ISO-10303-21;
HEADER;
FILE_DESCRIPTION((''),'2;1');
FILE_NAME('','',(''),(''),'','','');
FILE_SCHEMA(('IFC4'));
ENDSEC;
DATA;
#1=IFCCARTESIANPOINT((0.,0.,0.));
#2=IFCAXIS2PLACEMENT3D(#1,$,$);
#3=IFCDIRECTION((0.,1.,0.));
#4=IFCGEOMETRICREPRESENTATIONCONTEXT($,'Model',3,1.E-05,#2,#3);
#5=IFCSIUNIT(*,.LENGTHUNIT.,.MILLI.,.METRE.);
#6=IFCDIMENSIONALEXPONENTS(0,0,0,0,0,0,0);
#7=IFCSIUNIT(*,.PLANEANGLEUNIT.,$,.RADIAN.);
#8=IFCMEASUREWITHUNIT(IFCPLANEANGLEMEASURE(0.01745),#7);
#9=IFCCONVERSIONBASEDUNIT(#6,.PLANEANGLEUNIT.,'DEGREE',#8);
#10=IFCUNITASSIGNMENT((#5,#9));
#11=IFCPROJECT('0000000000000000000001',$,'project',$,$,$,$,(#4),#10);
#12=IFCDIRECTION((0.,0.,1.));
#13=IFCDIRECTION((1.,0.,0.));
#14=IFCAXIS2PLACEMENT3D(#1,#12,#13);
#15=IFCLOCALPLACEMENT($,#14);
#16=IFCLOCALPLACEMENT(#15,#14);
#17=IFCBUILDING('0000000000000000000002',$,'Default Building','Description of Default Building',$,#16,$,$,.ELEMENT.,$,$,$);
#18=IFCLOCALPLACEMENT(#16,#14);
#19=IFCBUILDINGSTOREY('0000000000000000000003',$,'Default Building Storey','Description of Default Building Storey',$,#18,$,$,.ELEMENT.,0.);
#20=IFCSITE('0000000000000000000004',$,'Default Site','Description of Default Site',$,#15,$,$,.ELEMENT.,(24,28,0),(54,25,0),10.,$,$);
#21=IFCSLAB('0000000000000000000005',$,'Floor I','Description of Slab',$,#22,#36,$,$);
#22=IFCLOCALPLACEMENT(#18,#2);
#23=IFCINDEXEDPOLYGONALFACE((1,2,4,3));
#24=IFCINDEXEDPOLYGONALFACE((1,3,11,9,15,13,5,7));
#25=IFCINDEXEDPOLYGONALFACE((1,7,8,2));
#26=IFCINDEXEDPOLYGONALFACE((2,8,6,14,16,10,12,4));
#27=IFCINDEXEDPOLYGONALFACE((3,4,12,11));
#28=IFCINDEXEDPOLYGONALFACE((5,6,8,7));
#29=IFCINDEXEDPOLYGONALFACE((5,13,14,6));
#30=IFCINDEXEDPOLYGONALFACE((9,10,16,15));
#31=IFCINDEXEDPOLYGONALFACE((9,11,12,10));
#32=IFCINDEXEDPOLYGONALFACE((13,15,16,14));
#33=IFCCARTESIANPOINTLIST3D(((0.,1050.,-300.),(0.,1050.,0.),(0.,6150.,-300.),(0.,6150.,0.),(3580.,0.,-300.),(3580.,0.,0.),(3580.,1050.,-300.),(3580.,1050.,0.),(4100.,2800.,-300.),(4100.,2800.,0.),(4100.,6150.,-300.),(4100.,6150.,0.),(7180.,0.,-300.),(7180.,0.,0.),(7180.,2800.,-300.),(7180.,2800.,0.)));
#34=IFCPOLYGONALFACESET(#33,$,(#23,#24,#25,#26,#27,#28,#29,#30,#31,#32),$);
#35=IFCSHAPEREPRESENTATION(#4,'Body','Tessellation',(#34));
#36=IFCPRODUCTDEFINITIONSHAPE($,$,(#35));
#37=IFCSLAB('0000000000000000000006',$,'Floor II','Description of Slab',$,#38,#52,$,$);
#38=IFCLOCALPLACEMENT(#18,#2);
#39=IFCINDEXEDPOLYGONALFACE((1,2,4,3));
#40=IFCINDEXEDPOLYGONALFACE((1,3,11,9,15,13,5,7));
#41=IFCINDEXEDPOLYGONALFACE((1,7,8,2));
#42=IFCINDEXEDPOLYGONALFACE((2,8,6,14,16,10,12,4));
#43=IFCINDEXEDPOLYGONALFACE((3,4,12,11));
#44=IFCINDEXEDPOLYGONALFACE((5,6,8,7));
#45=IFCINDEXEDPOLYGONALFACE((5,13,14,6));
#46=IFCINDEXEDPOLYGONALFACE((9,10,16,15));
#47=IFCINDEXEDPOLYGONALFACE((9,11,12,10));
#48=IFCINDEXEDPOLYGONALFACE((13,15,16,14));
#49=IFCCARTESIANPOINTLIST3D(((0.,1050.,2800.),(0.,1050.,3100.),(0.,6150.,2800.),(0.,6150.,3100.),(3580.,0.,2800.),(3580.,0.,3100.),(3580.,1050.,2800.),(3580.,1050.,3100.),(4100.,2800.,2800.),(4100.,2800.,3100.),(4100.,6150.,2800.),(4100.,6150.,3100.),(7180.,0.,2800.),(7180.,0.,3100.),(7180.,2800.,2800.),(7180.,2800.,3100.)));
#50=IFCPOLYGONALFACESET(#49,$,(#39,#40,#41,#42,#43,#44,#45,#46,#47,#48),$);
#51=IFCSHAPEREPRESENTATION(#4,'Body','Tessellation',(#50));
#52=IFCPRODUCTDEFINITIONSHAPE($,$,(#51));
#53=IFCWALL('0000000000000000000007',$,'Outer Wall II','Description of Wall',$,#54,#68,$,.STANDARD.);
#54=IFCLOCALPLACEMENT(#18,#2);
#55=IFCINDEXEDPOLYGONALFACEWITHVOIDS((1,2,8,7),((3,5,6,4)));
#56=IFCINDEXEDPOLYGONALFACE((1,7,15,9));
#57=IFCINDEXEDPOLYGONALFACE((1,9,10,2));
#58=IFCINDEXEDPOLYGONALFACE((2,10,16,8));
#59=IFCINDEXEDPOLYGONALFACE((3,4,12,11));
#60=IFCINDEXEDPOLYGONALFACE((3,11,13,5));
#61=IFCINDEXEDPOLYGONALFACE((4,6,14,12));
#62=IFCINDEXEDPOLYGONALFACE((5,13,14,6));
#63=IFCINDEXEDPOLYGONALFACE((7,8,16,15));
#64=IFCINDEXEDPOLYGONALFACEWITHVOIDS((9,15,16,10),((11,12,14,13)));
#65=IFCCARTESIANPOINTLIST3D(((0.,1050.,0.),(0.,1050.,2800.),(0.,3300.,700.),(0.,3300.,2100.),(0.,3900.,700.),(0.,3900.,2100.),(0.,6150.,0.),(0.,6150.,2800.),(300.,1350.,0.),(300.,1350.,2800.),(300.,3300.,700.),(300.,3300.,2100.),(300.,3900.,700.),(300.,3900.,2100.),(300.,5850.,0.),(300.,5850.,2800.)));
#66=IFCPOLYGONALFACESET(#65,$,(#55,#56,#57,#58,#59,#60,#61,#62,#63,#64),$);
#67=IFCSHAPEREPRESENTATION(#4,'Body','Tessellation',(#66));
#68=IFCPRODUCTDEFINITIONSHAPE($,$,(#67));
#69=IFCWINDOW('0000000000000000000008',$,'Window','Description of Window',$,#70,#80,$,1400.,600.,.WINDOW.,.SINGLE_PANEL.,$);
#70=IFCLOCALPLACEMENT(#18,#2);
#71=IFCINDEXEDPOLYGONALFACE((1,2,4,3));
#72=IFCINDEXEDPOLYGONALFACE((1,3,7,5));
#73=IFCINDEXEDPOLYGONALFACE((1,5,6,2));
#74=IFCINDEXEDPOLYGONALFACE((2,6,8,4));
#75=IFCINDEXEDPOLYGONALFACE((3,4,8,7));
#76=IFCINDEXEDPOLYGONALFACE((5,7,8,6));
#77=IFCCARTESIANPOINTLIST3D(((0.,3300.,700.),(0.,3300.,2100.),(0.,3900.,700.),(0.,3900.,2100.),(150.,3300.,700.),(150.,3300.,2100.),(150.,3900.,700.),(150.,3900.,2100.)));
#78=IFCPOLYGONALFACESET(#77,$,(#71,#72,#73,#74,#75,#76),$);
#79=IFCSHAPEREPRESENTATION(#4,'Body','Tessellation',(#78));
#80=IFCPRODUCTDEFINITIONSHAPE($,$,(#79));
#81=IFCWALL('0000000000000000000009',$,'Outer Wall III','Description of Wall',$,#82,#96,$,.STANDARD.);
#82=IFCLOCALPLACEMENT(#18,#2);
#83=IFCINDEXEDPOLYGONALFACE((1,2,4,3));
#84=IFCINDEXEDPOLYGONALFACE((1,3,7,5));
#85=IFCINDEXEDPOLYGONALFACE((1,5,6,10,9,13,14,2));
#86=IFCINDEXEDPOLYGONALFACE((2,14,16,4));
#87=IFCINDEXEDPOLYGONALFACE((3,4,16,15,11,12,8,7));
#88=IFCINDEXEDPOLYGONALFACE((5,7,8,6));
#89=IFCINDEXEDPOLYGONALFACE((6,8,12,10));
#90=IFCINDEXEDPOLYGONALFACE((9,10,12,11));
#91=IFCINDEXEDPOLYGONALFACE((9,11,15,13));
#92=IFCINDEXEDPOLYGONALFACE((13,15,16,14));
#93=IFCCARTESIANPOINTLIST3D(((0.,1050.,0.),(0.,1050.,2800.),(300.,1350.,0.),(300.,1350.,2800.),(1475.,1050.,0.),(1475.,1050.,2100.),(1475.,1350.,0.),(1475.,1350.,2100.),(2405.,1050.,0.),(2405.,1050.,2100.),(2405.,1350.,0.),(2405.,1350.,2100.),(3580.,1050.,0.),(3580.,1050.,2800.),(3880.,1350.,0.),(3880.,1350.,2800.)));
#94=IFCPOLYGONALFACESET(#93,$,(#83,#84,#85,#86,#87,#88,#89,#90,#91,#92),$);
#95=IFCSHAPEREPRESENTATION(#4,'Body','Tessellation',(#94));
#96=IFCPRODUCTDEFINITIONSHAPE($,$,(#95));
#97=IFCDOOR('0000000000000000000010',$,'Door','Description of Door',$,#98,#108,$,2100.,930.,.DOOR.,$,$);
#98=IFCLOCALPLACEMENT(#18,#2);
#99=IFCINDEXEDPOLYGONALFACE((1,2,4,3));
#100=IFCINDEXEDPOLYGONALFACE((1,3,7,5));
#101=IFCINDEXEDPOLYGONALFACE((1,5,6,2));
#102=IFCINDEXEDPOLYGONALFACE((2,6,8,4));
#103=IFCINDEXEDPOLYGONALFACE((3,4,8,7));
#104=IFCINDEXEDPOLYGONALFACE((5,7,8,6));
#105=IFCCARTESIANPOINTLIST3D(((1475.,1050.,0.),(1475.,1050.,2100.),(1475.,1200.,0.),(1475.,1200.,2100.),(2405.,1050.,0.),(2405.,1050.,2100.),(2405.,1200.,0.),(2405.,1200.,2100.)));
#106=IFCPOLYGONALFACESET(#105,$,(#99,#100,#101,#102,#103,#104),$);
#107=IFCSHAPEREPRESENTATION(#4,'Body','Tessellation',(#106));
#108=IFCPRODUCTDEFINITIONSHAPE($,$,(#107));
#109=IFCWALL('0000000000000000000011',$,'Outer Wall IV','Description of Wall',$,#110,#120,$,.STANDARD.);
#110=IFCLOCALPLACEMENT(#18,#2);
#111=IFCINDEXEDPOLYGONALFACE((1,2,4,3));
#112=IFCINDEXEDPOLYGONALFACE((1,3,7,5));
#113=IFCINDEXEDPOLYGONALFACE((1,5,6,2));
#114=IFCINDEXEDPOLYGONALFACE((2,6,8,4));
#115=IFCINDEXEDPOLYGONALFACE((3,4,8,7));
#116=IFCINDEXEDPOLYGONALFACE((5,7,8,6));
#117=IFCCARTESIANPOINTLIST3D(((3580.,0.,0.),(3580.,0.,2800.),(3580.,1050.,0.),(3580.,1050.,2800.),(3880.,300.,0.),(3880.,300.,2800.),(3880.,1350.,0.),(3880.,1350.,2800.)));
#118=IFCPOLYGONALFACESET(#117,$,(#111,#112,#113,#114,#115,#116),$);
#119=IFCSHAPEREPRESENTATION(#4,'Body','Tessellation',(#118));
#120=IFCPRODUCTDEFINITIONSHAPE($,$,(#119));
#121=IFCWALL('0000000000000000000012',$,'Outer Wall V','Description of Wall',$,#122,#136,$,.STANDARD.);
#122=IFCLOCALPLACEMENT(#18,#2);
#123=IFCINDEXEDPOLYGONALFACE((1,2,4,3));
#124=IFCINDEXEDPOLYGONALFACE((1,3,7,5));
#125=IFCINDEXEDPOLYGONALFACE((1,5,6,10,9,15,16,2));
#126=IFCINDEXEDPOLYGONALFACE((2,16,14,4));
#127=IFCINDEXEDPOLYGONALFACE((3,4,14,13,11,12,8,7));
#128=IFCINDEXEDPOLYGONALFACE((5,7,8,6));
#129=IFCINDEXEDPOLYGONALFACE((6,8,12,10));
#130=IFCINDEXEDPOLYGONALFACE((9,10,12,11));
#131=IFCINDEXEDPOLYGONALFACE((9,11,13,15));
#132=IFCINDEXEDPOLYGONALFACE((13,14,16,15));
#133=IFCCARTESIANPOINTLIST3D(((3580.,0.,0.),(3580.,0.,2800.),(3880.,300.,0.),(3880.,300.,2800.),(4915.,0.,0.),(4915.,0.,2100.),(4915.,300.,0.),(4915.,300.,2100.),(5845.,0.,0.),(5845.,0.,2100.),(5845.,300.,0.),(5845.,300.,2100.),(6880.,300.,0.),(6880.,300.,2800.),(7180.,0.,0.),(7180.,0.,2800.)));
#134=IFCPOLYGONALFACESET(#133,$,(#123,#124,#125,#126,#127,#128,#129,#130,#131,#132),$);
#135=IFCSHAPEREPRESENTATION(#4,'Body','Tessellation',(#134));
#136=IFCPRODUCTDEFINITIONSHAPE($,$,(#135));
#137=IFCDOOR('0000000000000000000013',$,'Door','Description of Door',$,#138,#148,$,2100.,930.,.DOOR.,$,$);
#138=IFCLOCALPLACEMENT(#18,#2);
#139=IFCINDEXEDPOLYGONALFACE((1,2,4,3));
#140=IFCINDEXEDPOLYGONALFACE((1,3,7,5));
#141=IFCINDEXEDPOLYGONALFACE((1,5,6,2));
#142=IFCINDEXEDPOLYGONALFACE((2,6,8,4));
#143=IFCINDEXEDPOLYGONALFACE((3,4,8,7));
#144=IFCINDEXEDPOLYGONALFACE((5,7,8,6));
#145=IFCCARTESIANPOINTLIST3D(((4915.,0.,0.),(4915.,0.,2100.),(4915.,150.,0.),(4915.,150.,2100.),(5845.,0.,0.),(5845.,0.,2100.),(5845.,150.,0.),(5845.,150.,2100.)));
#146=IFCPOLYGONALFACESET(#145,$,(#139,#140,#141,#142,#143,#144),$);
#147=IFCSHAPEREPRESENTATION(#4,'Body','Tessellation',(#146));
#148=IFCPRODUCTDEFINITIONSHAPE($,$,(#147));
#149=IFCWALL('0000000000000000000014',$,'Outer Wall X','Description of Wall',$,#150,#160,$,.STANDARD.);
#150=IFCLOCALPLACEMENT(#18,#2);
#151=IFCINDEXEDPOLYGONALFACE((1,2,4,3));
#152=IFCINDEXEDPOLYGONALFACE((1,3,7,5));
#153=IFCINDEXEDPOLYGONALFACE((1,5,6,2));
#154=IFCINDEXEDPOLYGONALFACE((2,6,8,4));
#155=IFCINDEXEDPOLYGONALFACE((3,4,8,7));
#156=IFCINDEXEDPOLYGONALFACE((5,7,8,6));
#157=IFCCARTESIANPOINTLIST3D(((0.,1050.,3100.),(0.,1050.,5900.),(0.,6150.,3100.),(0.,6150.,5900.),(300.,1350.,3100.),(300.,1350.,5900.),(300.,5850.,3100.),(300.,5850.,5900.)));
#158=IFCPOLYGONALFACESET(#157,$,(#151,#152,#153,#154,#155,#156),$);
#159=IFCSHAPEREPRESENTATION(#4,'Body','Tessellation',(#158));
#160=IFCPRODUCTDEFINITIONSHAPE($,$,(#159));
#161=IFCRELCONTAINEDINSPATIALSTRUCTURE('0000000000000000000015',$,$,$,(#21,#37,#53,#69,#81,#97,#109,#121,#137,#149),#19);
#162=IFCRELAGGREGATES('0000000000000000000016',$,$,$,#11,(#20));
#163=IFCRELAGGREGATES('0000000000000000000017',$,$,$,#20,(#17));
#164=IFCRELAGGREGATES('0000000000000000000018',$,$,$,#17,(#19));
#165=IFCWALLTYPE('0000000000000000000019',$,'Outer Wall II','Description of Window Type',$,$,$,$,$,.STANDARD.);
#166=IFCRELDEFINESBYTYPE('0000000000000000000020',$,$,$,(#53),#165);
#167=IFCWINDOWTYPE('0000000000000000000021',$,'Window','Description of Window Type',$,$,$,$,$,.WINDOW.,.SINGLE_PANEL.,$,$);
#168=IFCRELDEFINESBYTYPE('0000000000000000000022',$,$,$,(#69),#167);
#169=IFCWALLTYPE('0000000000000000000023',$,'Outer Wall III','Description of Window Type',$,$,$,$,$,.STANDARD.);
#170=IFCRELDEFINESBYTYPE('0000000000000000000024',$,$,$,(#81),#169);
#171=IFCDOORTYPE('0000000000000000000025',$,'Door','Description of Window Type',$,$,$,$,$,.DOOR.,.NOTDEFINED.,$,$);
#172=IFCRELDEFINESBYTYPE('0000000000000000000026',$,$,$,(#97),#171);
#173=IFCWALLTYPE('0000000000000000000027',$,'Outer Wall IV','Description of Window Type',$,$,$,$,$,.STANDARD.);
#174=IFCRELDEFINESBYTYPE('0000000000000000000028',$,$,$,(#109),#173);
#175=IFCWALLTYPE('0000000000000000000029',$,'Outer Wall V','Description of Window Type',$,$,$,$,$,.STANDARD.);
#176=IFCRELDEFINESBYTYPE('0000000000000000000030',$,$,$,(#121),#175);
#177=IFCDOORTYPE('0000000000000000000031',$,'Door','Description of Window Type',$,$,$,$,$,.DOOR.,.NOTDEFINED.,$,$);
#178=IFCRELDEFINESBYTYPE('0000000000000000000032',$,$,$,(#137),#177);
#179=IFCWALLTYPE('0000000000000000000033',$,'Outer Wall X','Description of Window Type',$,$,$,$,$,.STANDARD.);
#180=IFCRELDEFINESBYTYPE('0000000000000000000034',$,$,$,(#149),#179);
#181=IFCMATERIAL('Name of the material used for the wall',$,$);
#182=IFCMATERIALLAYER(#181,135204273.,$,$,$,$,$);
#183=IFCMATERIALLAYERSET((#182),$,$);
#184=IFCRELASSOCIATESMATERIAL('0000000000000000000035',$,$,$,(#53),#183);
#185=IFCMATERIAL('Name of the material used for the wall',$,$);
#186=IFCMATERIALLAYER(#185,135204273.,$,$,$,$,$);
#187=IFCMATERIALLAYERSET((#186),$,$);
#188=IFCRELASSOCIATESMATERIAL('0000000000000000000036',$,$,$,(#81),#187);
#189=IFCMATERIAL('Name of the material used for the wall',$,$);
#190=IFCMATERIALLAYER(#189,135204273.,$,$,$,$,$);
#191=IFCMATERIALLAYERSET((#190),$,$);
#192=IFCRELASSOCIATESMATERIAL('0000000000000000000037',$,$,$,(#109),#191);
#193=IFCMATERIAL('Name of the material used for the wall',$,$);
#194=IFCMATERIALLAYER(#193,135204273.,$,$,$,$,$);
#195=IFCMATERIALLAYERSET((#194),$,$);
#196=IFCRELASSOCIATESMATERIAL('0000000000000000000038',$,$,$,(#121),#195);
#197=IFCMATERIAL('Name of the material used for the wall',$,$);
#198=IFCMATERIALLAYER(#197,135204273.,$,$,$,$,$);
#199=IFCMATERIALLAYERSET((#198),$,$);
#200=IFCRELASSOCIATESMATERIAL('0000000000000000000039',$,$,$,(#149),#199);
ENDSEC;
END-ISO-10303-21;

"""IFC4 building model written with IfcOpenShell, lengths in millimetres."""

from ifc_helpers import new_model, entity, si_unit, converted_unit, direction, frame, origin, origin_with_axes, place, context, project, spatial, polyline, outline, extrude, material, layer, layer_set, layer_usage, type_object, element, fill, save


model = new_model("IFC4")

# Units and contexts
model_context = context("Model", 3, precision=1e-05, world=origin(), true_north=direction((0.0, 1.0, 0.0)))
ifc_project = project(units=[si_unit("LENGTHUNIT", "METRE", prefix="MILLI"), converted_unit("PLANEANGLEUNIT", "DEGREE", entity("IfcPlaneAngleMeasure", 0.01745), si_unit("PLANEANGLEUNIT", "RADIAN"), dimensions=[0, 0, 0, 0, 0, 0, 0])], contexts=[model_context])

# Site, building, storey
site_placement = place(None, origin_with_axes())
site = spatial("IfcSite", under=ifc_project, at=site_placement, Name="Default Site", Description="Description of Default Site", CompositionType="ELEMENT", RefLatitude=(24, 28, 0), RefLongitude=(54, 25, 0), RefElevation=10.0)
building_placement = place(site_placement, origin_with_axes())
building = spatial("IfcBuilding", under=site, at=building_placement, Name="Default Building", Description="Description of Default Building", CompositionType="ELEMENT")
storey_placement = place(building_placement, origin_with_axes())
storey = spatial("IfcBuildingStorey", under=building, at=storey_placement, Name="Default Building Storey", Description="Description of Default Building Storey", CompositionType="ELEMENT", Elevation=0.0)

# Slabs
for number, where, z_axis, x_axis, name in (
    (1, (0.0, 0.0, -300.0), (0.0, 0.0, 1.0), (1.0, 0.0, 0.0), "Floor I"),
    (2, (0.0, 0.0, 2800.0), (0.0, 0.0, 1.0), (1.0, 0.0, 0.0), "Floor II"),
):
    element("IfcSlab", number, at=place(storey_placement, frame(where, z_axis=z_axis, x_axis=x_axis)), inside=storey, Name=name, Description="Description of Slab", context=model_context, shape_type="SweptSolid", body=[
        extrude(outline(polyline([(0.0, 1050.0), (0.0, 6150.0), (4100.0, 6150.0), (4100.0, 2800.0), (7180.0, 2800.0), (7180.0, 0.0), (3580.0, 0.0), (3580.0, 1050.0), (0.0, 1050.0)])), origin_with_axes(), (0.0, 0.0, 1.0), 300.0),
    ])

# Wall, opening, window
ifc_material_1 = material(Name="Name of the material used for the wall")
ifc_layer_1 = layer(ifc_material_1, 135204273.0)
ifc_layer_set_1 = layer_set([ifc_layer_1])
ifc_layer_usage_1 = layer_usage(ifc_layer_set_1, "AXIS2", "POSITIVE", -67602136.5)
wall_type_1 = type_object("IfcWallType", Name="Outer Wall II", Description="Description of Window Type", PredefinedType="STANDARD")
wall_1_placement = place(storey_placement, frame((150.0, 6000.0, 0.0), z_axis=(0.0, 0.0, 1.0), x_axis=(0.0, -1.0, 0.0)))
wall_1 = element("IfcWall", 3, at=wall_1_placement, inside=storey, type_object=wall_type_1, material=ifc_layer_usage_1, Name="Outer Wall II", Description="Description of Wall", PredefinedType="STANDARD", context=model_context, shape_type="SweptSolid", body=[
    extrude(outline(polyline([(-150.0, -150.0), (150.0, 150.0), (4650.0, 150.0), (4950.0, -150.0), (-150.0, -150.0)])), origin_with_axes(), (0.0, 0.0, 1.0), 2800.0),
])
opening_1_placement = place(wall_1_placement, frame((2100.0, -150.0, 700.0), z_axis=(0.0, 0.0, 1.0), x_axis=(1.0, 0.0, 0.0)))
opening_1 = element("IfcOpeningElement", 4, at=opening_1_placement, cuts=wall_1, context=model_context, shape_type="SweptSolid", body=[
    extrude(outline(polyline([(0.0, 0.0), (0.0, 300.0), (600.0, 300.0), (600.0, 0.0), (0.0, 0.0)])), origin_with_axes(), (0.0, 0.0, 1.0), 1400.0),
])
window_type_1 = type_object("IfcWindowType", Name="Window", Description="Description of Window Type", PartitioningType="SINGLE_PANEL", PredefinedType="WINDOW")
window_1_placement = place(opening_1_placement, origin_with_axes())
window_1 = element("IfcWindow", 5, at=window_1_placement, inside=storey, type_object=window_type_1, Name="Window", Description="Description of Window", OverallHeight=1400.0, OverallWidth=600.0, PartitioningType="SINGLE_PANEL", PredefinedType="WINDOW", context=model_context, shape_type="SweptSolid", body=[
    extrude(outline(polyline([(0.0, 0.0), (0.0, 150.0), (600.0, 150.0), (600.0, 0.0), (0.0, 0.0)])), origin_with_axes(), (0.0, 0.0, 1.0), 1400.0),
])
fill(opening_1, window_1)

# Wall, opening, door
ifc_material_2 = material(Name="Name of the material used for the wall")
ifc_layer_2 = layer(ifc_material_2, 135204273.0)
ifc_layer_set_2 = layer_set([ifc_layer_2])
ifc_layer_usage_2 = layer_usage(ifc_layer_set_2, "AXIS2", "POSITIVE", -67602136.5)
wall_type_2 = type_object("IfcWallType", Name="Outer Wall III", Description="Description of Window Type", PredefinedType="STANDARD")
wall_2_placement = place(storey_placement, frame((150.0, 1200.0, 0.0), z_axis=(0.0, 0.0, 1.0), x_axis=(1.0, 0.0, 0.0)))
wall_2 = element("IfcWall", 6, at=wall_2_placement, inside=storey, type_object=wall_type_2, material=ifc_layer_usage_2, Name="Outer Wall III", Description="Description of Wall", PredefinedType="STANDARD", context=model_context, shape_type="SweptSolid", body=[
    extrude(outline(polyline([(-150.0, -150.0), (150.0, 150.0), (3730.0, 150.0), (3430.0, -150.0), (-150.0, -150.0)])), origin_with_axes(), (0.0, 0.0, 1.0), 2800.0),
])
opening_2_placement = place(wall_2_placement, frame((1325.0, -150.0, 0.0), z_axis=(0.0, 0.0, 1.0), x_axis=(1.0, 0.0, 0.0)))
opening_2 = element("IfcOpeningElement", 7, at=opening_2_placement, cuts=wall_2, context=model_context, shape_type="SweptSolid", body=[
    extrude(outline(polyline([(0.0, 0.0), (0.0, 300.0), (930.0, 300.0), (930.0, 0.0), (0.0, 0.0)])), origin_with_axes(), (0.0, 0.0, 1.0), 2100.0),
])
door_type_1 = type_object("IfcDoorType", Name="Door", Description="Description of Window Type", PredefinedType="DOOR")
door_1_placement = place(opening_2_placement, origin_with_axes())
door_1 = element("IfcDoor", 8, at=door_1_placement, inside=storey, type_object=door_type_1, Name="Door", Description="Description of Door", OverallHeight=2100.0, OverallWidth=930.0, PredefinedType="DOOR", context=model_context, shape_type="SweptSolid", body=[
    extrude(outline(polyline([(0.0, 0.0), (0.0, 150.0), (930.0, 150.0), (930.0, 0.0), (0.0, 0.0)])), origin_with_axes(), (0.0, 0.0, 1.0), 2100.0),
])
fill(opening_2, door_1)

# Wall
ifc_material_3 = material(Name="Name of the material used for the wall")
ifc_layer_3 = layer(ifc_material_3, 135204273.0)
ifc_layer_set_3 = layer_set([ifc_layer_3])
ifc_layer_usage_3 = layer_usage(ifc_layer_set_3, "AXIS2", "POSITIVE", -67602136.5)
wall_type_3 = type_object("IfcWallType", Name="Outer Wall IV", Description="Description of Window Type", PredefinedType="STANDARD")
wall_3_placement = place(storey_placement, frame((3730.0, 1200.0, 0.0), z_axis=(0.0, 0.0, 1.0), x_axis=(0.0, -1.0, 0.0)))
element("IfcWall", 9, at=wall_3_placement, inside=storey, type_object=wall_type_3, material=ifc_layer_usage_3, Name="Outer Wall IV", Description="Description of Wall", PredefinedType="STANDARD", context=model_context, shape_type="SweptSolid", body=[
    extrude(outline(polyline([(150.0, -150.0), (-150.0, 150.0), (900.0, 150.0), (1200.0, -150.0), (150.0, -150.0)])), origin_with_axes(), (0.0, 0.0, 1.0), 2800.0),
])

# Wall, opening, door
ifc_material_4 = material(Name="Name of the material used for the wall")
ifc_layer_4 = layer(ifc_material_4, 135204273.0)
ifc_layer_set_4 = layer_set([ifc_layer_4])
ifc_layer_usage_4 = layer_usage(ifc_layer_set_4, "AXIS2", "POSITIVE", -67602136.5)
wall_type_4 = type_object("IfcWallType", Name="Outer Wall V", Description="Description of Window Type", PredefinedType="STANDARD")
wall_4_placement = place(storey_placement, frame((3730.0, 150.0, 0.0), z_axis=(0.0, 0.0, 1.0), x_axis=(1.0, 0.0, 0.0)))
wall_4 = element("IfcWall", 10, at=wall_4_placement, inside=storey, type_object=wall_type_4, material=ifc_layer_usage_4, Name="Outer Wall V", Description="Description of Wall", PredefinedType="STANDARD", context=model_context, shape_type="SweptSolid", body=[
    extrude(outline(polyline([(-150.0, -150.0), (150.0, 150.0), (3150.0, 150.0), (3450.0, -150.0), (-150.0, -150.0)])), origin_with_axes(), (0.0, 0.0, 1.0), 2800.0),
])
opening_3_placement = place(wall_4_placement, frame((1185.0, -150.0, 0.0), z_axis=(0.0, 0.0, 1.0), x_axis=(1.0, 0.0, 0.0)))
opening_3 = element("IfcOpeningElement", 11, at=opening_3_placement, cuts=wall_4, context=model_context, shape_type="SweptSolid", body=[
    extrude(outline(polyline([(0.0, 0.0), (0.0, 300.0), (930.0, 300.0), (930.0, 0.0), (0.0, 0.0)])), origin_with_axes(), (0.0, 0.0, 1.0), 2100.0),
])
door_type_2 = type_object("IfcDoorType", Name="Door", Description="Description of Window Type", PredefinedType="DOOR")
door_2_placement = place(opening_3_placement, origin_with_axes())
door_2 = element("IfcDoor", 12, at=door_2_placement, inside=storey, type_object=door_type_2, Name="Door", Description="Description of Door", OverallHeight=2100.0, OverallWidth=930.0, PredefinedType="DOOR", context=model_context, shape_type="SweptSolid", body=[
    extrude(outline(polyline([(0.0, 0.0), (0.0, 150.0), (930.0, 150.0), (930.0, 0.0), (0.0, 0.0)])), origin_with_axes(), (0.0, 0.0, 1.0), 2100.0),
])
fill(opening_3, door_2)

# Wall
ifc_material_5 = material(Name="Name of the material used for the wall")
ifc_layer_5 = layer(ifc_material_5, 135204273.0)
ifc_layer_set_5 = layer_set([ifc_layer_5])
ifc_layer_usage_5 = layer_usage(ifc_layer_set_5, "AXIS2", "POSITIVE", -67602136.5)
wall_type_5 = type_object("IfcWallType", Name="Outer Wall X", Description="Description of Window Type", PredefinedType="STANDARD")
wall_5_placement = place(storey_placement, frame((150.0, 6000.0, 3100.0), z_axis=(0.0, 0.0, 1.0), x_axis=(0.0, -1.0, 0.0)))
element("IfcWall", 13, at=wall_5_placement, inside=storey, type_object=wall_type_5, material=ifc_layer_usage_5, Name="Outer Wall X", Description="Description of Wall", PredefinedType="STANDARD", context=model_context, shape_type="SweptSolid", body=[
    extrude(outline(polyline([(-150.0, -150.0), (150.0, 150.0), (4650.0, 150.0), (4950.0, -150.0), (-150.0, -150.0)])), origin_with_axes(), (0.0, 0.0, 1.0), 2800.0),
])

save(model, "model.ifc")
